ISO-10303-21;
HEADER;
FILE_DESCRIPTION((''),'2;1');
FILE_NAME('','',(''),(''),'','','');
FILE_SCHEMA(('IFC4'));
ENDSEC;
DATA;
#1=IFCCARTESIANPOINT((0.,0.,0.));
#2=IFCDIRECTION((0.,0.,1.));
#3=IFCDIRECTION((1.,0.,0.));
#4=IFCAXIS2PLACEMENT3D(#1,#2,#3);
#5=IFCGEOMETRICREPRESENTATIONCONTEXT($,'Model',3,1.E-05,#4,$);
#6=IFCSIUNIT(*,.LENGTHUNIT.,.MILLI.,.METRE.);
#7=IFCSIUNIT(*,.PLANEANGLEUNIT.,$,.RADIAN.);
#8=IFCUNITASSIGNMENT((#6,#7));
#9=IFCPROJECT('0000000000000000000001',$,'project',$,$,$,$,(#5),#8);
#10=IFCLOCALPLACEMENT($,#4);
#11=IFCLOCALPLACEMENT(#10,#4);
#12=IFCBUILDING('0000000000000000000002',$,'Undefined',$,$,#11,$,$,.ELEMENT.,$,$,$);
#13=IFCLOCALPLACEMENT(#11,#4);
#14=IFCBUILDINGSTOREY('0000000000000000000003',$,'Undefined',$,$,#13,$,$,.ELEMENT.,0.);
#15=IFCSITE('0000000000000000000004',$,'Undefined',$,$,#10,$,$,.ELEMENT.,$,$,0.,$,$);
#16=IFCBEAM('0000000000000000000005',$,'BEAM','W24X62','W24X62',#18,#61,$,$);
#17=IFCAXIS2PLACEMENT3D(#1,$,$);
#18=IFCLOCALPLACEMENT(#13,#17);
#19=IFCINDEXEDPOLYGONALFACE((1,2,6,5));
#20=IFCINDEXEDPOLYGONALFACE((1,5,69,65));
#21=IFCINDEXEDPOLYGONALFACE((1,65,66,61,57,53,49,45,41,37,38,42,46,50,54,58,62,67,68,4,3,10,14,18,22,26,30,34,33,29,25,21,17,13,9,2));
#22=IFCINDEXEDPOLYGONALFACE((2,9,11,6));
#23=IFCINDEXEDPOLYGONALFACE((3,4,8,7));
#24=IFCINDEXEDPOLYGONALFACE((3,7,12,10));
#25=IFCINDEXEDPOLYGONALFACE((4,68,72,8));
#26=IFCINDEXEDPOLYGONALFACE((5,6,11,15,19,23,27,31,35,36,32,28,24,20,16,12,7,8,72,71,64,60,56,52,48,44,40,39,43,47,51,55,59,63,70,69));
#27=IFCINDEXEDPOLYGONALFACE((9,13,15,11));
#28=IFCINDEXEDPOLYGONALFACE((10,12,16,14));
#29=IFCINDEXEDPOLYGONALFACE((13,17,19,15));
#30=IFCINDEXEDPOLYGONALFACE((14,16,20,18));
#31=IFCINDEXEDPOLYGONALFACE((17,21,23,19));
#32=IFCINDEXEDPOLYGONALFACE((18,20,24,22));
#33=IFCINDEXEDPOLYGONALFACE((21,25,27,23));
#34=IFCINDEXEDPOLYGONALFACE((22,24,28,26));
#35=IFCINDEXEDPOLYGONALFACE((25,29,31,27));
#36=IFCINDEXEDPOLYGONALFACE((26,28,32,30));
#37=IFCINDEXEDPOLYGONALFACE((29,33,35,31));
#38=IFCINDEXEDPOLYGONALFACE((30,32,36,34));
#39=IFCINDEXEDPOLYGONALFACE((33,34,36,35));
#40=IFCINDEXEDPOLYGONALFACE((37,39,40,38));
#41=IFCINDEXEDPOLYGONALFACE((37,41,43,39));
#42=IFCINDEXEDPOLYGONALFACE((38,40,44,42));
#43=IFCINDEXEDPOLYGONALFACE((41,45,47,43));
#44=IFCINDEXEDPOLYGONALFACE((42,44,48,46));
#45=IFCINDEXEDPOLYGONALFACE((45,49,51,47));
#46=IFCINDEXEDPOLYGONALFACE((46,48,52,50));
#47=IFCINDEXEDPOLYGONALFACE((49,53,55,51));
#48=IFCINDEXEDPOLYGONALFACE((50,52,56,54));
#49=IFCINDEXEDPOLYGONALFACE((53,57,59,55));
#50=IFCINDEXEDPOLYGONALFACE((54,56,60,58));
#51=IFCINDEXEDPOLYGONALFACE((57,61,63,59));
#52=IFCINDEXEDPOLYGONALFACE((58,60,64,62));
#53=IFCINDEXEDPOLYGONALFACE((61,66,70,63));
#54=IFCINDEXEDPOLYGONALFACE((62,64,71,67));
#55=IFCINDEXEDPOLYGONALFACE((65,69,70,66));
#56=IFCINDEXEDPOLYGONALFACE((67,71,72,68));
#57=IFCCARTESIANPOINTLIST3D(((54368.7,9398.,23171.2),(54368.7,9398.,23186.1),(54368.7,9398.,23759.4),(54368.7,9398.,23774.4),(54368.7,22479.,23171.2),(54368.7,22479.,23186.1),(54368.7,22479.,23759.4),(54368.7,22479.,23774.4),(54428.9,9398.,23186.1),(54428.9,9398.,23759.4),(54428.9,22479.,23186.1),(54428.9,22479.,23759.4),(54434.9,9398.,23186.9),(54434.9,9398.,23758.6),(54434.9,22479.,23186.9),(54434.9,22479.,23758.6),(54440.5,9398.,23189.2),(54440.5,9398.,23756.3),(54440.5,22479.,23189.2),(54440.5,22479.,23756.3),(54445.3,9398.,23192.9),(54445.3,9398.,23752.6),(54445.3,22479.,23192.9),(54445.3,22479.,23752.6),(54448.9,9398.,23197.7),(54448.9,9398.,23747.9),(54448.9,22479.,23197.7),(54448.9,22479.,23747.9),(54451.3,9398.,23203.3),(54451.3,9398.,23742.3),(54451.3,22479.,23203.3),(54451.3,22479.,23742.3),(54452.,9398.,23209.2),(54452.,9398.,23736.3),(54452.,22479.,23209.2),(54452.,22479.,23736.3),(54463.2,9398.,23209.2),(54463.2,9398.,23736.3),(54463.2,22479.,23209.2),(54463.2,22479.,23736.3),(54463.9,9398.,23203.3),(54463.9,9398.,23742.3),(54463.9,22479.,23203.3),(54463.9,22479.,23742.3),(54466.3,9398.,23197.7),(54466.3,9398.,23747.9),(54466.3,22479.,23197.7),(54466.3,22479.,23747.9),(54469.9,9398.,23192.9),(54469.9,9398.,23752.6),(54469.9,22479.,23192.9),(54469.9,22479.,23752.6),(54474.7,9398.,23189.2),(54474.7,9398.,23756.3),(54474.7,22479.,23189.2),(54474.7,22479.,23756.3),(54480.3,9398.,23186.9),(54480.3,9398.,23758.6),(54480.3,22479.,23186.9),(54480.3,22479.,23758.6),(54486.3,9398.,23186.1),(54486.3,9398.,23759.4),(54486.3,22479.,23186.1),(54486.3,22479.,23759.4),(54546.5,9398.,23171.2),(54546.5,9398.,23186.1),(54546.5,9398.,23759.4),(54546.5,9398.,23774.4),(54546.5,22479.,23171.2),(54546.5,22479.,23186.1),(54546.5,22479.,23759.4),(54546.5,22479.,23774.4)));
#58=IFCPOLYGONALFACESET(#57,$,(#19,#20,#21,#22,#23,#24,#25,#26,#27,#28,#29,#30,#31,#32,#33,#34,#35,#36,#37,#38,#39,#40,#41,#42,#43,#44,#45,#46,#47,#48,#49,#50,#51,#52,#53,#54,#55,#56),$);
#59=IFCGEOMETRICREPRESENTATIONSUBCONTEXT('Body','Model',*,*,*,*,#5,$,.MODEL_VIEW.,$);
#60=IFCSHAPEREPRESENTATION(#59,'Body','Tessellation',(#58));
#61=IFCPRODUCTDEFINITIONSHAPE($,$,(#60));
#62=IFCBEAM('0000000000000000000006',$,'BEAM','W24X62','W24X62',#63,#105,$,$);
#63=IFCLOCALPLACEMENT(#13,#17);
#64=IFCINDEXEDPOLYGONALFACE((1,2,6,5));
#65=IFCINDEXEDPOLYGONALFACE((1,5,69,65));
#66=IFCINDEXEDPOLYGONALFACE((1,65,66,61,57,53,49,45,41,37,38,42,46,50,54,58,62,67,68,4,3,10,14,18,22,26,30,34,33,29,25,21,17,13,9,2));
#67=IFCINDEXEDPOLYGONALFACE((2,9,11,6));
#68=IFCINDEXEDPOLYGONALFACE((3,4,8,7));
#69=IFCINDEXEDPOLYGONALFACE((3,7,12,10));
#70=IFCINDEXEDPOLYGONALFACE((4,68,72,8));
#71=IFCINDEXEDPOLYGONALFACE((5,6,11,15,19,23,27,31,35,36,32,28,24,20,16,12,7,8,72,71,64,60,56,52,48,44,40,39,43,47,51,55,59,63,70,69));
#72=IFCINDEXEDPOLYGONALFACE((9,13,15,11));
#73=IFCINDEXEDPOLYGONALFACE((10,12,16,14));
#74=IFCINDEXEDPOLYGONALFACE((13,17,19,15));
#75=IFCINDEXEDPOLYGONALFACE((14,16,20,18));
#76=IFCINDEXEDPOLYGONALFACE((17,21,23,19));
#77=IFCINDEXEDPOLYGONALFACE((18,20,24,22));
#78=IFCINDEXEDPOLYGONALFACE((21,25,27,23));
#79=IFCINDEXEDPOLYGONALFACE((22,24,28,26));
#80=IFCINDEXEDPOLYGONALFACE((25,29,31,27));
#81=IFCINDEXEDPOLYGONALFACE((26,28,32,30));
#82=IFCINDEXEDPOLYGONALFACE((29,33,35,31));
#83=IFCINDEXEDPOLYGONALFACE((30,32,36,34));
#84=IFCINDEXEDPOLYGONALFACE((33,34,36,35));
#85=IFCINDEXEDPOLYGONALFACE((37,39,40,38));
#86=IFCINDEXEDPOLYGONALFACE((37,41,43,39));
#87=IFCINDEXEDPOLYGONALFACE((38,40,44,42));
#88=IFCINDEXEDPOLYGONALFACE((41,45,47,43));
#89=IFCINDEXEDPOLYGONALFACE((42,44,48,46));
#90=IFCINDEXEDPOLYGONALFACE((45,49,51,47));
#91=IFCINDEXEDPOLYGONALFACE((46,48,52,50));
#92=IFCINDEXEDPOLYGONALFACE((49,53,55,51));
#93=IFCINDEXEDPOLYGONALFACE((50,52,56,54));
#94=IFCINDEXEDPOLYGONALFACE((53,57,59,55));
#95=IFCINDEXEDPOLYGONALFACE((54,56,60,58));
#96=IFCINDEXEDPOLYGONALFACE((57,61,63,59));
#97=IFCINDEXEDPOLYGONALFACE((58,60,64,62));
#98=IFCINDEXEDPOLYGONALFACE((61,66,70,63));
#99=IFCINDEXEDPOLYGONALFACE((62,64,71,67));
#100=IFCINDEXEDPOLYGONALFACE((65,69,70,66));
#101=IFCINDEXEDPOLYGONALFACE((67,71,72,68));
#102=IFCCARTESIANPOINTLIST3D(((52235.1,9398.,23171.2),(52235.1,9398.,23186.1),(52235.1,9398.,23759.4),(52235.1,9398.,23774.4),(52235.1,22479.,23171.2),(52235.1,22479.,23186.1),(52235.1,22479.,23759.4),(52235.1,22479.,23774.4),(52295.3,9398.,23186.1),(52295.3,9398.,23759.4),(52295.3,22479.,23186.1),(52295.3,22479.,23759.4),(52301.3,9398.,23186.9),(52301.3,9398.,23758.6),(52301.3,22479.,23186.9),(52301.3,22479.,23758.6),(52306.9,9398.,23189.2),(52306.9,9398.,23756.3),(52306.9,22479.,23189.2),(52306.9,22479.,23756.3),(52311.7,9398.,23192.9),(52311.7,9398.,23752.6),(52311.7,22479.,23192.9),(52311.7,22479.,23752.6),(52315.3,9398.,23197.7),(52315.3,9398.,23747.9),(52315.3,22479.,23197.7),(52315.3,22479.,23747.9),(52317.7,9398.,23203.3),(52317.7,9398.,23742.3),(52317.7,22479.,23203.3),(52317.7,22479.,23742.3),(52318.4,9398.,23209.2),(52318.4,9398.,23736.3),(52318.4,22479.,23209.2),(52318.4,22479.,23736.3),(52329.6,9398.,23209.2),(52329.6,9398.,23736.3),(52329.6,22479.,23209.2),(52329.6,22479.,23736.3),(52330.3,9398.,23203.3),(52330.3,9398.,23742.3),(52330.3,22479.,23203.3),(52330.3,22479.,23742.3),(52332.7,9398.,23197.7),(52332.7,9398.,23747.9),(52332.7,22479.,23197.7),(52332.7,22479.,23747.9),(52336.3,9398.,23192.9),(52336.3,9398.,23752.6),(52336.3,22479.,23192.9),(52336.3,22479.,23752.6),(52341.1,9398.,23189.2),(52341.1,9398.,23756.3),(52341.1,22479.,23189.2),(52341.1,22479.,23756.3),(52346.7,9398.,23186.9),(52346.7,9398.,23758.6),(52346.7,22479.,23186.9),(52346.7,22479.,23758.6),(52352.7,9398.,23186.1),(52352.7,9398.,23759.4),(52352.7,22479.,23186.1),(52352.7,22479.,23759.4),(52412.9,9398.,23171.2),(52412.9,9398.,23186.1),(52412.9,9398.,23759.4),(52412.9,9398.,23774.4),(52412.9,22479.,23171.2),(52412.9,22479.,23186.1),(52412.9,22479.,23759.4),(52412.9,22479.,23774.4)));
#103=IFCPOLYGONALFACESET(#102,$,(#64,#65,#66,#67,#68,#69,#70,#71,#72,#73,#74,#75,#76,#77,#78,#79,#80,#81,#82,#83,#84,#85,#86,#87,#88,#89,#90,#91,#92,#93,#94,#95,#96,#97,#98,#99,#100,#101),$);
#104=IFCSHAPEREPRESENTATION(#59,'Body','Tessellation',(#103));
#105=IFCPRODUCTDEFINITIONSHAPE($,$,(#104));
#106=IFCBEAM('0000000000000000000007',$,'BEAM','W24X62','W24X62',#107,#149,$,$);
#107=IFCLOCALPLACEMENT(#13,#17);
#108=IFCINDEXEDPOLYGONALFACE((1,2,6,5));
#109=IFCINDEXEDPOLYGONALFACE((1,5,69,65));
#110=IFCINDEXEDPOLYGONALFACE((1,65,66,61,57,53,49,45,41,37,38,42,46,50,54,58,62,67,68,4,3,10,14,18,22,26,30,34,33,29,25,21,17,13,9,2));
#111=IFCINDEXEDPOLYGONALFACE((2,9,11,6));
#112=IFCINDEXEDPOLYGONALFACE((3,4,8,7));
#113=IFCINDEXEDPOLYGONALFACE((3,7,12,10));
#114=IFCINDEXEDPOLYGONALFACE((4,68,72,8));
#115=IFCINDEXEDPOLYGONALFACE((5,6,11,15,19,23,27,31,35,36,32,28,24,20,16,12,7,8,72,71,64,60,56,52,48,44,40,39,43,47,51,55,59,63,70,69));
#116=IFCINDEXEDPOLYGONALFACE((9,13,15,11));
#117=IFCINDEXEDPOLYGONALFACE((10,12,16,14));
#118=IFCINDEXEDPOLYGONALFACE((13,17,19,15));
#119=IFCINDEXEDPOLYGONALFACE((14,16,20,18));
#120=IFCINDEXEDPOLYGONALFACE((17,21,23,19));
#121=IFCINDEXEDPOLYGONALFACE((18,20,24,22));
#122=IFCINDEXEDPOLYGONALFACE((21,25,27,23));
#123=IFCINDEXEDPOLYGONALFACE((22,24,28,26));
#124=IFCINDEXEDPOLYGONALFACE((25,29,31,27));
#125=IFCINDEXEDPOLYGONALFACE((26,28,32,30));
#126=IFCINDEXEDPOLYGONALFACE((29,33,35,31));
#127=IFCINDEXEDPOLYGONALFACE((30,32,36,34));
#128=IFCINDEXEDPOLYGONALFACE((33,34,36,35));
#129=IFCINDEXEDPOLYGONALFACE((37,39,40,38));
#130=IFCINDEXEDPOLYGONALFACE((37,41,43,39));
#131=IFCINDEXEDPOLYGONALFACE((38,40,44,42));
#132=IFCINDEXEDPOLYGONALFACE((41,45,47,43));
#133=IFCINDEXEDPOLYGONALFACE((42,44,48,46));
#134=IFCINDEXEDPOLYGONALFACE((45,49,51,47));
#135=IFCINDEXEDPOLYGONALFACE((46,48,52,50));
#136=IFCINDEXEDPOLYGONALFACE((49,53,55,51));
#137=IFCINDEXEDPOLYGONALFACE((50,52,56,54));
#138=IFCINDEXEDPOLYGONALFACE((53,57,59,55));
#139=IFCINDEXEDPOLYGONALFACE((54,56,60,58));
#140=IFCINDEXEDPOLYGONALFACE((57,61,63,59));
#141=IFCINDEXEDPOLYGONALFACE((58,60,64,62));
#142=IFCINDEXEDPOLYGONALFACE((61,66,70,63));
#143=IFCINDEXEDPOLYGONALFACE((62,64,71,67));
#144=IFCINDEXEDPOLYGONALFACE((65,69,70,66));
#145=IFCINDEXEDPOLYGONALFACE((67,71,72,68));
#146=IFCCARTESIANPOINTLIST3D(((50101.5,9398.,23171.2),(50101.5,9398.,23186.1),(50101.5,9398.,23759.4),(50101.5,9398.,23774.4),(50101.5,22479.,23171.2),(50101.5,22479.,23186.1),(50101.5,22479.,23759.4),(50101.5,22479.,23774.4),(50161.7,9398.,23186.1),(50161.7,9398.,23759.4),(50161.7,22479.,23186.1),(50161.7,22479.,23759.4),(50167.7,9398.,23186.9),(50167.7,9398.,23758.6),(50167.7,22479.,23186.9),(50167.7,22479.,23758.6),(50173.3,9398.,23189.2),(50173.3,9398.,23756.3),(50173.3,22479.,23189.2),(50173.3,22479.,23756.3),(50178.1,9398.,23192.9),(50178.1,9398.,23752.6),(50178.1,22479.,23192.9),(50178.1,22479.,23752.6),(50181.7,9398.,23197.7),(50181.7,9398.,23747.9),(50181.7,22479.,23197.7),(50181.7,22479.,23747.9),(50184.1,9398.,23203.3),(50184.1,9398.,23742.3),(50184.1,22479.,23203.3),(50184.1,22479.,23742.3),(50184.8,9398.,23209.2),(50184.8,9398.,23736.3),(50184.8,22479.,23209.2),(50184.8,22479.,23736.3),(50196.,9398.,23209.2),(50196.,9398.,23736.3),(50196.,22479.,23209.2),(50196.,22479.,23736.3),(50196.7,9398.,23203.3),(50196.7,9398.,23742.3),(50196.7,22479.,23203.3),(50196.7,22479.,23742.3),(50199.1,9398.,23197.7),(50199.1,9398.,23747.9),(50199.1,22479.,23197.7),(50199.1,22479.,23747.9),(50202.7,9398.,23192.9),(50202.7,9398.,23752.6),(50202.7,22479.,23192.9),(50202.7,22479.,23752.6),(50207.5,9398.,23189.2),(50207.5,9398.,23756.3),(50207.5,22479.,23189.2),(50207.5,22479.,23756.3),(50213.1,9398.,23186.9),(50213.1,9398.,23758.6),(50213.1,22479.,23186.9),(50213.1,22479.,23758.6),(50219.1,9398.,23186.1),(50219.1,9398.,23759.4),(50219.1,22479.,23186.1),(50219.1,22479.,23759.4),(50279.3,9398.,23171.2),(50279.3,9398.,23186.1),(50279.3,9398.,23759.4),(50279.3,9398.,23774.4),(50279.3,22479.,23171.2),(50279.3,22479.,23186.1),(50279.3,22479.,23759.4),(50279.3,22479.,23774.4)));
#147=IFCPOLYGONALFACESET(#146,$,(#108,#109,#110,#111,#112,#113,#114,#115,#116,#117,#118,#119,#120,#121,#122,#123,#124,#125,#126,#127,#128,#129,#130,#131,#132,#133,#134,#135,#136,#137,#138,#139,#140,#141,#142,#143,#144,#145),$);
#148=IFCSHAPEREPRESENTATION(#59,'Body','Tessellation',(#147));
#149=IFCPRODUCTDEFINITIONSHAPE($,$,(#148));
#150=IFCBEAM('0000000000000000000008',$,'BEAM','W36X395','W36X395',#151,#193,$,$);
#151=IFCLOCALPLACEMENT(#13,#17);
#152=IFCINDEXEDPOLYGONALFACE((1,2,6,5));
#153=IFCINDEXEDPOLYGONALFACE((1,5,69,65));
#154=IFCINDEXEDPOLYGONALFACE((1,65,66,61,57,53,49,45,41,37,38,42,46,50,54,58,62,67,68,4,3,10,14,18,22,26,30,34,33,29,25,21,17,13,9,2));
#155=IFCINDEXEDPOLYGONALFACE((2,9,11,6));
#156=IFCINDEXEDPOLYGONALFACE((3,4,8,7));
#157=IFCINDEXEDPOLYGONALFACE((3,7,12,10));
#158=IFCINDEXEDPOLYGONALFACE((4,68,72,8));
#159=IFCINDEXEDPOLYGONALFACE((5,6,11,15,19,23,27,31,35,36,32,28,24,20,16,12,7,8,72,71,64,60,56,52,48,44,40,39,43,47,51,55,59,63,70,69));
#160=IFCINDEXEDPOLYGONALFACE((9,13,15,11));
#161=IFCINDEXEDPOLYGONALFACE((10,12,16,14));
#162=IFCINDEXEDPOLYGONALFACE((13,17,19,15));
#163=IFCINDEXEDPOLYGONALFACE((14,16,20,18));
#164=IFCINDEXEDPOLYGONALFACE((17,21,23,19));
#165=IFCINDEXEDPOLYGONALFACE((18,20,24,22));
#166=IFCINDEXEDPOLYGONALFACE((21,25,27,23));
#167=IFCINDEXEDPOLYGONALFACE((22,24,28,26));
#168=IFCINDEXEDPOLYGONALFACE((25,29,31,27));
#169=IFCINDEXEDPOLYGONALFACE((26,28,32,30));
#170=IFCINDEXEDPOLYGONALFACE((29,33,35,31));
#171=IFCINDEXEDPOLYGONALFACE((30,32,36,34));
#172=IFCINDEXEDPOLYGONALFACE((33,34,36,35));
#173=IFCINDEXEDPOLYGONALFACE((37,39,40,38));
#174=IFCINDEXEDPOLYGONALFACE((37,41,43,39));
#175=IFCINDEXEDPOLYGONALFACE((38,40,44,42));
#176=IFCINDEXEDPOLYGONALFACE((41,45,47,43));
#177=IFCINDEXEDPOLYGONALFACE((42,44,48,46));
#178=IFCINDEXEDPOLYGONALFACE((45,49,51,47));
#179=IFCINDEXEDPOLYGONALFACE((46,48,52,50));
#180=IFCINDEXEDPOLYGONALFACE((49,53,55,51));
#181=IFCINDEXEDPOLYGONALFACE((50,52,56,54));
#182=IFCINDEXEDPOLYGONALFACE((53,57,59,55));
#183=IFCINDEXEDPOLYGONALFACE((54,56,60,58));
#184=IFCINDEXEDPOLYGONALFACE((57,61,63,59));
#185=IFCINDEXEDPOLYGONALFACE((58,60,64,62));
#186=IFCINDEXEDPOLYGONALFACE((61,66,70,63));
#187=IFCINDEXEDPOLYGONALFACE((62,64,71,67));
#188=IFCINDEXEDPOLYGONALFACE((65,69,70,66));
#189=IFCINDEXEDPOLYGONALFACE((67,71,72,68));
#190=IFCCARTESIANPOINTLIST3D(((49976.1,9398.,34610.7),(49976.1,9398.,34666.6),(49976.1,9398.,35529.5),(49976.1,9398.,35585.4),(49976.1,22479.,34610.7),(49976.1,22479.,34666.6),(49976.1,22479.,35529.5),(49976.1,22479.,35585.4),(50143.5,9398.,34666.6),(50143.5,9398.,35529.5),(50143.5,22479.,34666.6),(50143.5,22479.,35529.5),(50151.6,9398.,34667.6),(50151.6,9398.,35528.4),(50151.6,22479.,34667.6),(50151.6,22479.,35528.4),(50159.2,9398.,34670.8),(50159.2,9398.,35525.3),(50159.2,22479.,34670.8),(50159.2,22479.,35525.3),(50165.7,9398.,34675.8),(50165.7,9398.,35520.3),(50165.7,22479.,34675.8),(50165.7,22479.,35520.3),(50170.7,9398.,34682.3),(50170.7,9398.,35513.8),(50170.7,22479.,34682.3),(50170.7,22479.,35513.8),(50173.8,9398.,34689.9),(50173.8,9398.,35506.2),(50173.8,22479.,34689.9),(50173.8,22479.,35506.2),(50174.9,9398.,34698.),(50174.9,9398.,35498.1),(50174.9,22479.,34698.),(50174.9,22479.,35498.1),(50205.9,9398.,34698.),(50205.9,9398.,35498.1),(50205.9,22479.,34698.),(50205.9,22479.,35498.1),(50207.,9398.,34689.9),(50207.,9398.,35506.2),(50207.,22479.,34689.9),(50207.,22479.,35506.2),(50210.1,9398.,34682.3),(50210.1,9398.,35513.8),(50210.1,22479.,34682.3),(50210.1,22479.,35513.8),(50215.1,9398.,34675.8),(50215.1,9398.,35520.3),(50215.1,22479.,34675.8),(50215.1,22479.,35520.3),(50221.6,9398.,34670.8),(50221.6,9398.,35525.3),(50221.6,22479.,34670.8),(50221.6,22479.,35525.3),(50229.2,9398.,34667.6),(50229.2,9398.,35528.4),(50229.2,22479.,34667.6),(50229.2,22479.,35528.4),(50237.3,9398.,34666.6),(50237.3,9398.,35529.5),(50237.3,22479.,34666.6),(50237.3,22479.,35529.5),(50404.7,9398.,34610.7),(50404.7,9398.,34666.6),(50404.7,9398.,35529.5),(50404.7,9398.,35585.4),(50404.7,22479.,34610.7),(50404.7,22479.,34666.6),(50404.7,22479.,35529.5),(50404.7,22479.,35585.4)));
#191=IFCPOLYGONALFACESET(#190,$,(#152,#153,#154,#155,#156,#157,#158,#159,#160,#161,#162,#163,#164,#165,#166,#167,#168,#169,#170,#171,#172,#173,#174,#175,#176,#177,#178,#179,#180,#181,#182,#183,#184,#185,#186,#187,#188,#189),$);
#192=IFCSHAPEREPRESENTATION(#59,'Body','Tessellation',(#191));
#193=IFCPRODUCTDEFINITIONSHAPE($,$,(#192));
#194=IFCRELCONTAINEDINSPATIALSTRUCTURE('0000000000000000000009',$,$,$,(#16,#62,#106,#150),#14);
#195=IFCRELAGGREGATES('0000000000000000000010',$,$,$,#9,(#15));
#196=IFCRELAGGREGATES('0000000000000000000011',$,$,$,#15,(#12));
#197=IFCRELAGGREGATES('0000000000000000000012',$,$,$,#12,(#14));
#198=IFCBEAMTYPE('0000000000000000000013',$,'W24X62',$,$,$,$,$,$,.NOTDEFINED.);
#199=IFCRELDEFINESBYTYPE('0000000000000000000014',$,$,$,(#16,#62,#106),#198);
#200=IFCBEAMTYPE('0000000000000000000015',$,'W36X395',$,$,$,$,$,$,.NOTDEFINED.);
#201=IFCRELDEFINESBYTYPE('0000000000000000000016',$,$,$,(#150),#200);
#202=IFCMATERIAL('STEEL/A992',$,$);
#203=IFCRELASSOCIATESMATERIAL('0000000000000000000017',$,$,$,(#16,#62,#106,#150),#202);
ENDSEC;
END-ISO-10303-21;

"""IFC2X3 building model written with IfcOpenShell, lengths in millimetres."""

from ifc_helpers import new_model, si_unit, frame, origin_with_axes, origin_2d_with_axis, place, context, subcontext, project, spatial, i_section, extrude, material, type_object, element, save


model = new_model("IFC2X3")

# Units and contexts
model_context = context("Model", 3, precision=1e-05, world=origin_with_axes())
body_context = subcontext(model_context, "Body", "Model", "MODEL_VIEW")
ifc_project = project(units=[si_unit("LENGTHUNIT", "METRE", prefix="MILLI"), si_unit("PLANEANGLEUNIT", "RADIAN")], contexts=[model_context])

# Site, building, storey
site_placement = place(None, origin_with_axes())
site = spatial("IfcSite", under=ifc_project, at=site_placement, Name="Undefined", CompositionType="ELEMENT", RefElevation=0.0)
building_placement = place(site_placement, origin_with_axes())
building = spatial("IfcBuilding", under=site, at=building_placement, Name="Undefined", CompositionType="ELEMENT")
storey_placement = place(building_placement, origin_with_axes())
storey = spatial("IfcBuildingStorey", under=building, at=storey_placement, Name="Undefined", CompositionType="ELEMENT", Elevation=0.0)

# Shared definitions
ifc_material_1 = material(Name="STEEL/A992")

# Beams
beam_type_1 = type_object("IfcBeamType", Name="W24X62", PredefinedType="NOTDEFINED")
for number, where, z_axis, x_axis, name in (
    (1, (54457.6, 9398.0, 23472.8), (0.0, 0.0, 1.0), (0.0, 1.0, 0.0), "BEAM"),
    (2, (52324.0, 9398.0, 23472.8), (0.0, 0.0, 1.0), (0.0, 1.0, 0.0), "BEAM"),
    (3, (50190.4, 9398.0, 23472.8), (0.0, 0.0, 1.0), (0.0, 1.0, 0.0), "BEAM"),
):
    element("IfcBeam", number, at=place(storey_placement, frame(where, z_axis=z_axis, x_axis=x_axis)), inside=storey, type_object=beam_type_1, material=ifc_material_1, Name=name, Description="W24X62", ObjectType="W24X62", context=body_context, shape_type="SweptSolid", body=[
        extrude(i_section(OverallWidth=177.8, OverallDepth=603.2, WebThickness=11.1, FlangeThickness=15.0, FilletRadius=23.1, at=origin_2d_with_axis()), frame((13081.0, 0.0, 0.0), z_axis=(-1.0, 0.0, 0.0), x_axis=(0.0, -1.0, 0.0)), (0.0, 0.0, 1.0), 13081.0),
    ])
beam_type_2 = type_object("IfcBeamType", Name="W36X395", PredefinedType="NOTDEFINED")
beam_1_placement = place(storey_placement, frame((50190.4, 9398.0, 35098.0), z_axis=(0.0, 0.0, 1.0), x_axis=(0.0, 1.0, 0.0)))
element("IfcBeam", 4, at=beam_1_placement, inside=storey, type_object=beam_type_2, material=ifc_material_1, Name="BEAM", Description="W36X395", ObjectType="W36X395", context=body_context, shape_type="SweptSolid", body=[
    extrude(i_section(OverallWidth=428.6, OverallDepth=974.7, WebThickness=31.0, FlangeThickness=55.9, FilletRadius=31.4, at=origin_2d_with_axis()), frame((13081.0, 0.0, 0.0), z_axis=(-1.0, 0.0, 0.0), x_axis=(0.0, -1.0, 0.0)), (0.0, 0.0, 1.0), 13081.0),
])

save(model, "model.ifc")
